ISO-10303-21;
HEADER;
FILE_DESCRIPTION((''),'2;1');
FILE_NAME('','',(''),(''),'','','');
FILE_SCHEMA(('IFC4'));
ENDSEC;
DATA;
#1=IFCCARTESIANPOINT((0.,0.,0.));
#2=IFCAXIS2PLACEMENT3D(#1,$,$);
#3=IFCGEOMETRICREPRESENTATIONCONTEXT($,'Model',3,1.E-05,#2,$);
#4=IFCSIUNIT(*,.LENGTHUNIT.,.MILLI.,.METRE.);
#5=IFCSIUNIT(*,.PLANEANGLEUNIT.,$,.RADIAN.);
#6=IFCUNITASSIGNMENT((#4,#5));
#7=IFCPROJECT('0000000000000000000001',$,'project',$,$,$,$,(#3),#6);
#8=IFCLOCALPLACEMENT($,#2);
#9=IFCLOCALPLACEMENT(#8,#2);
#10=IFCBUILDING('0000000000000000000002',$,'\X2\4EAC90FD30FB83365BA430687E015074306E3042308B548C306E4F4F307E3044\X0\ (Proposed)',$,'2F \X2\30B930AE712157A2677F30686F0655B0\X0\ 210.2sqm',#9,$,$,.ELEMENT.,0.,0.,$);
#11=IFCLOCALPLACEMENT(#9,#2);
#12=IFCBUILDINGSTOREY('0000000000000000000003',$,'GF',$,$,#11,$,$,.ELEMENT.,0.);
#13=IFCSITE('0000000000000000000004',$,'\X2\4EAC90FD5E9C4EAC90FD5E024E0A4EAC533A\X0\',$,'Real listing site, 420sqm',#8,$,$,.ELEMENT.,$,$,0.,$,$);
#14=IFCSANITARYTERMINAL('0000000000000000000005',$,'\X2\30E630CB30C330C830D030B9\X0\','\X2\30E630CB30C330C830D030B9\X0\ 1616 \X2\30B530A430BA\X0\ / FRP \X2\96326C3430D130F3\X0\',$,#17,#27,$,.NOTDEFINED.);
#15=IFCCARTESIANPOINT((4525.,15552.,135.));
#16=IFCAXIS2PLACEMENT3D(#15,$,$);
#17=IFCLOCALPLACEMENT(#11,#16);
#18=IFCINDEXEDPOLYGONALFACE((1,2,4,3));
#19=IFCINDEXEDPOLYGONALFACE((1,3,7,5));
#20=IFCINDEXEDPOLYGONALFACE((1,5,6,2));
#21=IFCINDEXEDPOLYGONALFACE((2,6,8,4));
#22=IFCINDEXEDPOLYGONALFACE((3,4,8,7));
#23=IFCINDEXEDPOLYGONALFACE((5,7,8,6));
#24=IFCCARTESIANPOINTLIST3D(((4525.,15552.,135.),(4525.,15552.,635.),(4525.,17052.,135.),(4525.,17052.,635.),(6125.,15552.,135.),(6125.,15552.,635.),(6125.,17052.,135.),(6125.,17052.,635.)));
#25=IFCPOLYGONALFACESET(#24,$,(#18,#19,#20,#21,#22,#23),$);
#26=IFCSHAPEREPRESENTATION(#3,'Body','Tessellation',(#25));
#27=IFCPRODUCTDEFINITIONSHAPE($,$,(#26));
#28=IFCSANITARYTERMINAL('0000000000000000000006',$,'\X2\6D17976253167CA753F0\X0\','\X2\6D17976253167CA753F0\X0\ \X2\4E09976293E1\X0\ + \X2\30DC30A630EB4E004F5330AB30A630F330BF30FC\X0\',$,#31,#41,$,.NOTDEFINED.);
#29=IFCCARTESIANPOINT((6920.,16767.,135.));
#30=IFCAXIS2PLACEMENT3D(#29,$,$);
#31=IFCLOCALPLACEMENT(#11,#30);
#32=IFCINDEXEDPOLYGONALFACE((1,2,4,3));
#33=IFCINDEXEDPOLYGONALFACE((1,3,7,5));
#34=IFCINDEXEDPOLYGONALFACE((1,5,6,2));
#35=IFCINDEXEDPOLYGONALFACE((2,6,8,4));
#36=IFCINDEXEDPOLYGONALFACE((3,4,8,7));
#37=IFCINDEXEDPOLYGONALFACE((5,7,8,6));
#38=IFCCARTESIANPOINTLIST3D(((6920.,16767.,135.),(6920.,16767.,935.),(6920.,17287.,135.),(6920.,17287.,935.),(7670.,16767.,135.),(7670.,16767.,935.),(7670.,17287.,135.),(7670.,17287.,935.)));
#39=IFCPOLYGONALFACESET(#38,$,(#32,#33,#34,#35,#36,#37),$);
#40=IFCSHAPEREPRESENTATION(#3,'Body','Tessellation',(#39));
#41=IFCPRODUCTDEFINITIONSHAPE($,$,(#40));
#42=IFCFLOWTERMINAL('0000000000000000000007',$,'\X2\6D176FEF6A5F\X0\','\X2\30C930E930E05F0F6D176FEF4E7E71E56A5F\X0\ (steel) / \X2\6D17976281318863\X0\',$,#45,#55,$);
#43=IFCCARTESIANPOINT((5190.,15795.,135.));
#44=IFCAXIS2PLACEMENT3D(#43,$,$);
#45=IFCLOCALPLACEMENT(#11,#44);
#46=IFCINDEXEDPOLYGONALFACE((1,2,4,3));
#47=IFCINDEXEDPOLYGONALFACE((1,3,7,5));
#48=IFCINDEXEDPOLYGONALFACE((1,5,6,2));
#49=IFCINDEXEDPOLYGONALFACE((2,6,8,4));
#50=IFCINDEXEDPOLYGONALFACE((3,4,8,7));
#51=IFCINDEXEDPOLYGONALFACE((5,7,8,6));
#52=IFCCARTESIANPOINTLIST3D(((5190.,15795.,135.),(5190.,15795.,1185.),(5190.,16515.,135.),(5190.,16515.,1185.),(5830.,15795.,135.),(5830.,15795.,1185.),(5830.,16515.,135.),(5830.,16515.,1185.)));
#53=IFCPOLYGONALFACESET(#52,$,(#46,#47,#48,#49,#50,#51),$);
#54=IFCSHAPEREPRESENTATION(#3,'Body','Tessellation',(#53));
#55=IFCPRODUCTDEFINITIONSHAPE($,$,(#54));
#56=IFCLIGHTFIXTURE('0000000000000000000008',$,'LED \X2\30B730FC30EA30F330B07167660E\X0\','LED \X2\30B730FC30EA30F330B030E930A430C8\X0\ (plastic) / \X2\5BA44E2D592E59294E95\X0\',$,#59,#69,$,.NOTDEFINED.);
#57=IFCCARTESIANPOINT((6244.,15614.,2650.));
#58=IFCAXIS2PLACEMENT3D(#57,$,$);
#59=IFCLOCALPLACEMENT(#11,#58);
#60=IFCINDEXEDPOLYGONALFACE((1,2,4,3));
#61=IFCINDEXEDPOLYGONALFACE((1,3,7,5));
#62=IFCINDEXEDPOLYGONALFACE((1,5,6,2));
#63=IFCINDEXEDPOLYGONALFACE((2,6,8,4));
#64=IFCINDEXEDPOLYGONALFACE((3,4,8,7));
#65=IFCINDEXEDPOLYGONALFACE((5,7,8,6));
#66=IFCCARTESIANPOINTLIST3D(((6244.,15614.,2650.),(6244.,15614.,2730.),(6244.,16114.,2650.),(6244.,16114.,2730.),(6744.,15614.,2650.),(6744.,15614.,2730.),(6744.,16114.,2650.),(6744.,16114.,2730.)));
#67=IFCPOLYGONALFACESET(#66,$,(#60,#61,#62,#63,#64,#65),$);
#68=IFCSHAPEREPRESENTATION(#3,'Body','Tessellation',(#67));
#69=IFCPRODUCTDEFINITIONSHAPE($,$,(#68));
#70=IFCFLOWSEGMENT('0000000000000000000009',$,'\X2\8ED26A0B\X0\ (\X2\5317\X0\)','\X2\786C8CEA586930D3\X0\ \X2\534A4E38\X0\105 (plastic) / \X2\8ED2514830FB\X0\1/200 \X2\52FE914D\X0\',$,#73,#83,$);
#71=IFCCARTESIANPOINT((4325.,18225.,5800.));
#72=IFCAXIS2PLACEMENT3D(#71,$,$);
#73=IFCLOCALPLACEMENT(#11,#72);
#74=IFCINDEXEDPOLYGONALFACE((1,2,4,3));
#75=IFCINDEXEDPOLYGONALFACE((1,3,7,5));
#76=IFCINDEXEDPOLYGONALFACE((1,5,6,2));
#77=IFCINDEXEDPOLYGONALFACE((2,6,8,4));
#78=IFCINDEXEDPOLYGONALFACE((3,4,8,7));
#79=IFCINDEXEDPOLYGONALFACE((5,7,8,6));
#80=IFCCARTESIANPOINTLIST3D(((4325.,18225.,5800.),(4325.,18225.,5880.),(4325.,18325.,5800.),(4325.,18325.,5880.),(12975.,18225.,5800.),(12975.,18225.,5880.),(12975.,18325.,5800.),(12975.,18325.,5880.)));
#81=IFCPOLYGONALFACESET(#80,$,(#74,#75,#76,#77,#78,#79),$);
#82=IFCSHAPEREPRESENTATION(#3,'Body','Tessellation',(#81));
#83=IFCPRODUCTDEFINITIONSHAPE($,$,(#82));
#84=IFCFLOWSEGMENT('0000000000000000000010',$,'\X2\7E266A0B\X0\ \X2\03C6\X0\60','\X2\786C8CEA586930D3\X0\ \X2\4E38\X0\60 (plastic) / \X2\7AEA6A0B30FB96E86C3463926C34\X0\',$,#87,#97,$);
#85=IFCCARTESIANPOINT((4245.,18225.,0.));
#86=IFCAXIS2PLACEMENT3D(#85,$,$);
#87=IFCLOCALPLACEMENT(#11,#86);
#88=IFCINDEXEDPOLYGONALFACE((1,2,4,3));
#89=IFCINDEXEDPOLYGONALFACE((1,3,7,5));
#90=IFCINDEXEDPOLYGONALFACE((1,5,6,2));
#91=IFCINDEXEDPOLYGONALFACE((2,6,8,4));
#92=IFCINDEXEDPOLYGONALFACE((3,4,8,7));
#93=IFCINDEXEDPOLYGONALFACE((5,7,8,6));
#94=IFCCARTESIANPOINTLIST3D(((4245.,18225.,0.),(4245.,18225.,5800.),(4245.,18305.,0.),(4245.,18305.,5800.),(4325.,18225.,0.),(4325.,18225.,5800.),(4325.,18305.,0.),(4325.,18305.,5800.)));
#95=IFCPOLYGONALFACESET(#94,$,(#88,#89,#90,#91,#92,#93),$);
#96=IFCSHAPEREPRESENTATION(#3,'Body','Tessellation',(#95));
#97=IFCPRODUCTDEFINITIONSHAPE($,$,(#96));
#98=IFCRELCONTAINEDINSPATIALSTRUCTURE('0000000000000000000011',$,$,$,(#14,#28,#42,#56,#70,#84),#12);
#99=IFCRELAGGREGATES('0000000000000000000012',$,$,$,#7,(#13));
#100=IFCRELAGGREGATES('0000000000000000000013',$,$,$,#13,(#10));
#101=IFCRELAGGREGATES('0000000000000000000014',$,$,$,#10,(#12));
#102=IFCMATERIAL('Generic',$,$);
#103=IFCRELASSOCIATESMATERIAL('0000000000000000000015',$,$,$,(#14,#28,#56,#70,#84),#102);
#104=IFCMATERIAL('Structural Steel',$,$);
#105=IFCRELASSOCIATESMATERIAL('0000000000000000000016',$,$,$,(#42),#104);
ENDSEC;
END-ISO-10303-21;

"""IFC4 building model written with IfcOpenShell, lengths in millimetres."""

from ifc_helpers import new_model, si_unit, frame, frame_2d, origin, place, context, project, spatial, rectangle, extrude, material, element, save


model = new_model("IFC4")

# Units and contexts
model_context = context("Model", 3, precision=1e-05, world=origin())
ifc_project = project(units=[si_unit("LENGTHUNIT", "METRE", prefix="MILLI"), si_unit("PLANEANGLEUNIT", "RADIAN")], contexts=[model_context])

# Site, building, storey
site_placement = place(None, origin())
site = spatial("IfcSite", under=ifc_project, at=site_placement, Name="京都府京都市上京区", ObjectType="Real listing site, 420sqm", CompositionType="ELEMENT", RefElevation=0.0)
building_placement = place(site_placement, origin())
building = spatial("IfcBuilding", under=site, at=building_placement, Name="京都・茶室と縁側のある和の住まい (Proposed)", ObjectType="2F スギ無垢板と漆喰 210.2sqm", CompositionType="ELEMENT", ElevationOfRefHeight=0.0, ElevationOfTerrain=0.0)
storey_placement = place(building_placement, origin())
storey = spatial("IfcBuildingStorey", under=building, at=storey_placement, Name="GF", CompositionType="ELEMENT", Elevation=0.0)

# Sanitary terminals
ifc_material_1 = material(Name="Generic")
sanitary_terminal_1_placement = place(storey_placement, frame((4525.0, 15552.0, 135.0)))
element("IfcSanitaryTerminal", 1, at=sanitary_terminal_1_placement, inside=storey, material=ifc_material_1, Name="ユニットバス", Description="ユニットバス 1616 サイズ / FRP 防水パン", PredefinedType="NOTDEFINED", context=model_context, shape_type="SweptSolid", body=[
    extrude(rectangle(XDim=1600.0, YDim=1500.0, at=frame_2d((800.0, 750.0))), frame((4525.0, 15552.0, 135.0)), (0.0, 0.0, 1.0), 500.0),
])
sanitary_terminal_2_placement = place(storey_placement, frame((6920.0, 16767.0, 135.0)))
element("IfcSanitaryTerminal", 2, at=sanitary_terminal_2_placement, inside=storey, material=ifc_material_1, Name="洗面化粧台", Description="洗面化粧台 三面鏡 + ボウル一体カウンター", PredefinedType="NOTDEFINED", context=model_context, shape_type="SweptSolid", body=[
    extrude(rectangle(XDim=750.0, YDim=520.0, at=frame_2d((375.0, 260.0))), frame((6920.0, 16767.0, 135.0)), (0.0, 0.0, 1.0), 800.0),
])

# Flow terminal
ifc_material_2 = material(Name="Structural Steel")
flow_terminal_placement = place(storey_placement, frame((5190.0, 15795.0, 135.0)))
element("IfcFlowTerminal", 3, at=flow_terminal_placement, inside=storey, material=ifc_material_2, Name="洗濯機", Description="ドラム式洗濯乾燥機 (steel) / 洗面脱衣", context=model_context, shape_type="SweptSolid", body=[
    extrude(rectangle(XDim=640.0, YDim=720.0, at=frame_2d((320.0, 360.0))), frame((5190.0, 15795.0, 135.0)), (0.0, 0.0, 1.0), 1050.0),
])

# Light fixture
light_fixture_placement = place(storey_placement, frame((6244.0, 15614.0, 2650.0)))
element("IfcLightFixture", 4, at=light_fixture_placement, inside=storey, material=ifc_material_1, Name="LED シーリング照明", Description="LED シーリングライト (plastic) / 室中央天井", PredefinedType="NOTDEFINED", context=model_context, shape_type="SweptSolid", body=[
    extrude(rectangle(XDim=500.0, YDim=500.0, at=frame_2d((250.0, 250.0))), frame((6244.0, 15614.0, 2650.0)), (0.0, 0.0, 1.0), 80.0),
])

# Flow segments
flow_segment_1_placement = place(storey_placement, frame((4325.0, 18225.0, 5800.0)))
element("IfcFlowSegment", 5, at=flow_segment_1_placement, inside=storey, material=ifc_material_1, Name="軒樋 (北)", Description="硬質塩ビ 半丸105 (plastic) / 軒先・1/200 勾配", context=model_context, shape_type="SweptSolid", body=[
    extrude(rectangle(XDim=8650.0, YDim=100.0, at=frame_2d((4325.0, 50.0))), frame((4325.0, 18225.0, 5800.0)), (0.0, 0.0, 1.0), 80.0),
])
flow_segment_2_placement = place(storey_placement, frame((4245.0, 18225.0, 0.0)))
element("IfcFlowSegment", 6, at=flow_segment_2_placement, inside=storey, material=ifc_material_1, Name="縦樋 φ60", Description="硬質塩ビ 丸60 (plastic) / 竪樋・雨水排水", context=model_context, shape_type="SweptSolid", body=[
    extrude(rectangle(XDim=80.0, YDim=80.0, at=frame_2d((40.0, 40.0))), frame((4245.0, 18225.0, 0.0)), (0.0, 0.0, 1.0), 5800.0),
])

save(model, "model.ifc")
